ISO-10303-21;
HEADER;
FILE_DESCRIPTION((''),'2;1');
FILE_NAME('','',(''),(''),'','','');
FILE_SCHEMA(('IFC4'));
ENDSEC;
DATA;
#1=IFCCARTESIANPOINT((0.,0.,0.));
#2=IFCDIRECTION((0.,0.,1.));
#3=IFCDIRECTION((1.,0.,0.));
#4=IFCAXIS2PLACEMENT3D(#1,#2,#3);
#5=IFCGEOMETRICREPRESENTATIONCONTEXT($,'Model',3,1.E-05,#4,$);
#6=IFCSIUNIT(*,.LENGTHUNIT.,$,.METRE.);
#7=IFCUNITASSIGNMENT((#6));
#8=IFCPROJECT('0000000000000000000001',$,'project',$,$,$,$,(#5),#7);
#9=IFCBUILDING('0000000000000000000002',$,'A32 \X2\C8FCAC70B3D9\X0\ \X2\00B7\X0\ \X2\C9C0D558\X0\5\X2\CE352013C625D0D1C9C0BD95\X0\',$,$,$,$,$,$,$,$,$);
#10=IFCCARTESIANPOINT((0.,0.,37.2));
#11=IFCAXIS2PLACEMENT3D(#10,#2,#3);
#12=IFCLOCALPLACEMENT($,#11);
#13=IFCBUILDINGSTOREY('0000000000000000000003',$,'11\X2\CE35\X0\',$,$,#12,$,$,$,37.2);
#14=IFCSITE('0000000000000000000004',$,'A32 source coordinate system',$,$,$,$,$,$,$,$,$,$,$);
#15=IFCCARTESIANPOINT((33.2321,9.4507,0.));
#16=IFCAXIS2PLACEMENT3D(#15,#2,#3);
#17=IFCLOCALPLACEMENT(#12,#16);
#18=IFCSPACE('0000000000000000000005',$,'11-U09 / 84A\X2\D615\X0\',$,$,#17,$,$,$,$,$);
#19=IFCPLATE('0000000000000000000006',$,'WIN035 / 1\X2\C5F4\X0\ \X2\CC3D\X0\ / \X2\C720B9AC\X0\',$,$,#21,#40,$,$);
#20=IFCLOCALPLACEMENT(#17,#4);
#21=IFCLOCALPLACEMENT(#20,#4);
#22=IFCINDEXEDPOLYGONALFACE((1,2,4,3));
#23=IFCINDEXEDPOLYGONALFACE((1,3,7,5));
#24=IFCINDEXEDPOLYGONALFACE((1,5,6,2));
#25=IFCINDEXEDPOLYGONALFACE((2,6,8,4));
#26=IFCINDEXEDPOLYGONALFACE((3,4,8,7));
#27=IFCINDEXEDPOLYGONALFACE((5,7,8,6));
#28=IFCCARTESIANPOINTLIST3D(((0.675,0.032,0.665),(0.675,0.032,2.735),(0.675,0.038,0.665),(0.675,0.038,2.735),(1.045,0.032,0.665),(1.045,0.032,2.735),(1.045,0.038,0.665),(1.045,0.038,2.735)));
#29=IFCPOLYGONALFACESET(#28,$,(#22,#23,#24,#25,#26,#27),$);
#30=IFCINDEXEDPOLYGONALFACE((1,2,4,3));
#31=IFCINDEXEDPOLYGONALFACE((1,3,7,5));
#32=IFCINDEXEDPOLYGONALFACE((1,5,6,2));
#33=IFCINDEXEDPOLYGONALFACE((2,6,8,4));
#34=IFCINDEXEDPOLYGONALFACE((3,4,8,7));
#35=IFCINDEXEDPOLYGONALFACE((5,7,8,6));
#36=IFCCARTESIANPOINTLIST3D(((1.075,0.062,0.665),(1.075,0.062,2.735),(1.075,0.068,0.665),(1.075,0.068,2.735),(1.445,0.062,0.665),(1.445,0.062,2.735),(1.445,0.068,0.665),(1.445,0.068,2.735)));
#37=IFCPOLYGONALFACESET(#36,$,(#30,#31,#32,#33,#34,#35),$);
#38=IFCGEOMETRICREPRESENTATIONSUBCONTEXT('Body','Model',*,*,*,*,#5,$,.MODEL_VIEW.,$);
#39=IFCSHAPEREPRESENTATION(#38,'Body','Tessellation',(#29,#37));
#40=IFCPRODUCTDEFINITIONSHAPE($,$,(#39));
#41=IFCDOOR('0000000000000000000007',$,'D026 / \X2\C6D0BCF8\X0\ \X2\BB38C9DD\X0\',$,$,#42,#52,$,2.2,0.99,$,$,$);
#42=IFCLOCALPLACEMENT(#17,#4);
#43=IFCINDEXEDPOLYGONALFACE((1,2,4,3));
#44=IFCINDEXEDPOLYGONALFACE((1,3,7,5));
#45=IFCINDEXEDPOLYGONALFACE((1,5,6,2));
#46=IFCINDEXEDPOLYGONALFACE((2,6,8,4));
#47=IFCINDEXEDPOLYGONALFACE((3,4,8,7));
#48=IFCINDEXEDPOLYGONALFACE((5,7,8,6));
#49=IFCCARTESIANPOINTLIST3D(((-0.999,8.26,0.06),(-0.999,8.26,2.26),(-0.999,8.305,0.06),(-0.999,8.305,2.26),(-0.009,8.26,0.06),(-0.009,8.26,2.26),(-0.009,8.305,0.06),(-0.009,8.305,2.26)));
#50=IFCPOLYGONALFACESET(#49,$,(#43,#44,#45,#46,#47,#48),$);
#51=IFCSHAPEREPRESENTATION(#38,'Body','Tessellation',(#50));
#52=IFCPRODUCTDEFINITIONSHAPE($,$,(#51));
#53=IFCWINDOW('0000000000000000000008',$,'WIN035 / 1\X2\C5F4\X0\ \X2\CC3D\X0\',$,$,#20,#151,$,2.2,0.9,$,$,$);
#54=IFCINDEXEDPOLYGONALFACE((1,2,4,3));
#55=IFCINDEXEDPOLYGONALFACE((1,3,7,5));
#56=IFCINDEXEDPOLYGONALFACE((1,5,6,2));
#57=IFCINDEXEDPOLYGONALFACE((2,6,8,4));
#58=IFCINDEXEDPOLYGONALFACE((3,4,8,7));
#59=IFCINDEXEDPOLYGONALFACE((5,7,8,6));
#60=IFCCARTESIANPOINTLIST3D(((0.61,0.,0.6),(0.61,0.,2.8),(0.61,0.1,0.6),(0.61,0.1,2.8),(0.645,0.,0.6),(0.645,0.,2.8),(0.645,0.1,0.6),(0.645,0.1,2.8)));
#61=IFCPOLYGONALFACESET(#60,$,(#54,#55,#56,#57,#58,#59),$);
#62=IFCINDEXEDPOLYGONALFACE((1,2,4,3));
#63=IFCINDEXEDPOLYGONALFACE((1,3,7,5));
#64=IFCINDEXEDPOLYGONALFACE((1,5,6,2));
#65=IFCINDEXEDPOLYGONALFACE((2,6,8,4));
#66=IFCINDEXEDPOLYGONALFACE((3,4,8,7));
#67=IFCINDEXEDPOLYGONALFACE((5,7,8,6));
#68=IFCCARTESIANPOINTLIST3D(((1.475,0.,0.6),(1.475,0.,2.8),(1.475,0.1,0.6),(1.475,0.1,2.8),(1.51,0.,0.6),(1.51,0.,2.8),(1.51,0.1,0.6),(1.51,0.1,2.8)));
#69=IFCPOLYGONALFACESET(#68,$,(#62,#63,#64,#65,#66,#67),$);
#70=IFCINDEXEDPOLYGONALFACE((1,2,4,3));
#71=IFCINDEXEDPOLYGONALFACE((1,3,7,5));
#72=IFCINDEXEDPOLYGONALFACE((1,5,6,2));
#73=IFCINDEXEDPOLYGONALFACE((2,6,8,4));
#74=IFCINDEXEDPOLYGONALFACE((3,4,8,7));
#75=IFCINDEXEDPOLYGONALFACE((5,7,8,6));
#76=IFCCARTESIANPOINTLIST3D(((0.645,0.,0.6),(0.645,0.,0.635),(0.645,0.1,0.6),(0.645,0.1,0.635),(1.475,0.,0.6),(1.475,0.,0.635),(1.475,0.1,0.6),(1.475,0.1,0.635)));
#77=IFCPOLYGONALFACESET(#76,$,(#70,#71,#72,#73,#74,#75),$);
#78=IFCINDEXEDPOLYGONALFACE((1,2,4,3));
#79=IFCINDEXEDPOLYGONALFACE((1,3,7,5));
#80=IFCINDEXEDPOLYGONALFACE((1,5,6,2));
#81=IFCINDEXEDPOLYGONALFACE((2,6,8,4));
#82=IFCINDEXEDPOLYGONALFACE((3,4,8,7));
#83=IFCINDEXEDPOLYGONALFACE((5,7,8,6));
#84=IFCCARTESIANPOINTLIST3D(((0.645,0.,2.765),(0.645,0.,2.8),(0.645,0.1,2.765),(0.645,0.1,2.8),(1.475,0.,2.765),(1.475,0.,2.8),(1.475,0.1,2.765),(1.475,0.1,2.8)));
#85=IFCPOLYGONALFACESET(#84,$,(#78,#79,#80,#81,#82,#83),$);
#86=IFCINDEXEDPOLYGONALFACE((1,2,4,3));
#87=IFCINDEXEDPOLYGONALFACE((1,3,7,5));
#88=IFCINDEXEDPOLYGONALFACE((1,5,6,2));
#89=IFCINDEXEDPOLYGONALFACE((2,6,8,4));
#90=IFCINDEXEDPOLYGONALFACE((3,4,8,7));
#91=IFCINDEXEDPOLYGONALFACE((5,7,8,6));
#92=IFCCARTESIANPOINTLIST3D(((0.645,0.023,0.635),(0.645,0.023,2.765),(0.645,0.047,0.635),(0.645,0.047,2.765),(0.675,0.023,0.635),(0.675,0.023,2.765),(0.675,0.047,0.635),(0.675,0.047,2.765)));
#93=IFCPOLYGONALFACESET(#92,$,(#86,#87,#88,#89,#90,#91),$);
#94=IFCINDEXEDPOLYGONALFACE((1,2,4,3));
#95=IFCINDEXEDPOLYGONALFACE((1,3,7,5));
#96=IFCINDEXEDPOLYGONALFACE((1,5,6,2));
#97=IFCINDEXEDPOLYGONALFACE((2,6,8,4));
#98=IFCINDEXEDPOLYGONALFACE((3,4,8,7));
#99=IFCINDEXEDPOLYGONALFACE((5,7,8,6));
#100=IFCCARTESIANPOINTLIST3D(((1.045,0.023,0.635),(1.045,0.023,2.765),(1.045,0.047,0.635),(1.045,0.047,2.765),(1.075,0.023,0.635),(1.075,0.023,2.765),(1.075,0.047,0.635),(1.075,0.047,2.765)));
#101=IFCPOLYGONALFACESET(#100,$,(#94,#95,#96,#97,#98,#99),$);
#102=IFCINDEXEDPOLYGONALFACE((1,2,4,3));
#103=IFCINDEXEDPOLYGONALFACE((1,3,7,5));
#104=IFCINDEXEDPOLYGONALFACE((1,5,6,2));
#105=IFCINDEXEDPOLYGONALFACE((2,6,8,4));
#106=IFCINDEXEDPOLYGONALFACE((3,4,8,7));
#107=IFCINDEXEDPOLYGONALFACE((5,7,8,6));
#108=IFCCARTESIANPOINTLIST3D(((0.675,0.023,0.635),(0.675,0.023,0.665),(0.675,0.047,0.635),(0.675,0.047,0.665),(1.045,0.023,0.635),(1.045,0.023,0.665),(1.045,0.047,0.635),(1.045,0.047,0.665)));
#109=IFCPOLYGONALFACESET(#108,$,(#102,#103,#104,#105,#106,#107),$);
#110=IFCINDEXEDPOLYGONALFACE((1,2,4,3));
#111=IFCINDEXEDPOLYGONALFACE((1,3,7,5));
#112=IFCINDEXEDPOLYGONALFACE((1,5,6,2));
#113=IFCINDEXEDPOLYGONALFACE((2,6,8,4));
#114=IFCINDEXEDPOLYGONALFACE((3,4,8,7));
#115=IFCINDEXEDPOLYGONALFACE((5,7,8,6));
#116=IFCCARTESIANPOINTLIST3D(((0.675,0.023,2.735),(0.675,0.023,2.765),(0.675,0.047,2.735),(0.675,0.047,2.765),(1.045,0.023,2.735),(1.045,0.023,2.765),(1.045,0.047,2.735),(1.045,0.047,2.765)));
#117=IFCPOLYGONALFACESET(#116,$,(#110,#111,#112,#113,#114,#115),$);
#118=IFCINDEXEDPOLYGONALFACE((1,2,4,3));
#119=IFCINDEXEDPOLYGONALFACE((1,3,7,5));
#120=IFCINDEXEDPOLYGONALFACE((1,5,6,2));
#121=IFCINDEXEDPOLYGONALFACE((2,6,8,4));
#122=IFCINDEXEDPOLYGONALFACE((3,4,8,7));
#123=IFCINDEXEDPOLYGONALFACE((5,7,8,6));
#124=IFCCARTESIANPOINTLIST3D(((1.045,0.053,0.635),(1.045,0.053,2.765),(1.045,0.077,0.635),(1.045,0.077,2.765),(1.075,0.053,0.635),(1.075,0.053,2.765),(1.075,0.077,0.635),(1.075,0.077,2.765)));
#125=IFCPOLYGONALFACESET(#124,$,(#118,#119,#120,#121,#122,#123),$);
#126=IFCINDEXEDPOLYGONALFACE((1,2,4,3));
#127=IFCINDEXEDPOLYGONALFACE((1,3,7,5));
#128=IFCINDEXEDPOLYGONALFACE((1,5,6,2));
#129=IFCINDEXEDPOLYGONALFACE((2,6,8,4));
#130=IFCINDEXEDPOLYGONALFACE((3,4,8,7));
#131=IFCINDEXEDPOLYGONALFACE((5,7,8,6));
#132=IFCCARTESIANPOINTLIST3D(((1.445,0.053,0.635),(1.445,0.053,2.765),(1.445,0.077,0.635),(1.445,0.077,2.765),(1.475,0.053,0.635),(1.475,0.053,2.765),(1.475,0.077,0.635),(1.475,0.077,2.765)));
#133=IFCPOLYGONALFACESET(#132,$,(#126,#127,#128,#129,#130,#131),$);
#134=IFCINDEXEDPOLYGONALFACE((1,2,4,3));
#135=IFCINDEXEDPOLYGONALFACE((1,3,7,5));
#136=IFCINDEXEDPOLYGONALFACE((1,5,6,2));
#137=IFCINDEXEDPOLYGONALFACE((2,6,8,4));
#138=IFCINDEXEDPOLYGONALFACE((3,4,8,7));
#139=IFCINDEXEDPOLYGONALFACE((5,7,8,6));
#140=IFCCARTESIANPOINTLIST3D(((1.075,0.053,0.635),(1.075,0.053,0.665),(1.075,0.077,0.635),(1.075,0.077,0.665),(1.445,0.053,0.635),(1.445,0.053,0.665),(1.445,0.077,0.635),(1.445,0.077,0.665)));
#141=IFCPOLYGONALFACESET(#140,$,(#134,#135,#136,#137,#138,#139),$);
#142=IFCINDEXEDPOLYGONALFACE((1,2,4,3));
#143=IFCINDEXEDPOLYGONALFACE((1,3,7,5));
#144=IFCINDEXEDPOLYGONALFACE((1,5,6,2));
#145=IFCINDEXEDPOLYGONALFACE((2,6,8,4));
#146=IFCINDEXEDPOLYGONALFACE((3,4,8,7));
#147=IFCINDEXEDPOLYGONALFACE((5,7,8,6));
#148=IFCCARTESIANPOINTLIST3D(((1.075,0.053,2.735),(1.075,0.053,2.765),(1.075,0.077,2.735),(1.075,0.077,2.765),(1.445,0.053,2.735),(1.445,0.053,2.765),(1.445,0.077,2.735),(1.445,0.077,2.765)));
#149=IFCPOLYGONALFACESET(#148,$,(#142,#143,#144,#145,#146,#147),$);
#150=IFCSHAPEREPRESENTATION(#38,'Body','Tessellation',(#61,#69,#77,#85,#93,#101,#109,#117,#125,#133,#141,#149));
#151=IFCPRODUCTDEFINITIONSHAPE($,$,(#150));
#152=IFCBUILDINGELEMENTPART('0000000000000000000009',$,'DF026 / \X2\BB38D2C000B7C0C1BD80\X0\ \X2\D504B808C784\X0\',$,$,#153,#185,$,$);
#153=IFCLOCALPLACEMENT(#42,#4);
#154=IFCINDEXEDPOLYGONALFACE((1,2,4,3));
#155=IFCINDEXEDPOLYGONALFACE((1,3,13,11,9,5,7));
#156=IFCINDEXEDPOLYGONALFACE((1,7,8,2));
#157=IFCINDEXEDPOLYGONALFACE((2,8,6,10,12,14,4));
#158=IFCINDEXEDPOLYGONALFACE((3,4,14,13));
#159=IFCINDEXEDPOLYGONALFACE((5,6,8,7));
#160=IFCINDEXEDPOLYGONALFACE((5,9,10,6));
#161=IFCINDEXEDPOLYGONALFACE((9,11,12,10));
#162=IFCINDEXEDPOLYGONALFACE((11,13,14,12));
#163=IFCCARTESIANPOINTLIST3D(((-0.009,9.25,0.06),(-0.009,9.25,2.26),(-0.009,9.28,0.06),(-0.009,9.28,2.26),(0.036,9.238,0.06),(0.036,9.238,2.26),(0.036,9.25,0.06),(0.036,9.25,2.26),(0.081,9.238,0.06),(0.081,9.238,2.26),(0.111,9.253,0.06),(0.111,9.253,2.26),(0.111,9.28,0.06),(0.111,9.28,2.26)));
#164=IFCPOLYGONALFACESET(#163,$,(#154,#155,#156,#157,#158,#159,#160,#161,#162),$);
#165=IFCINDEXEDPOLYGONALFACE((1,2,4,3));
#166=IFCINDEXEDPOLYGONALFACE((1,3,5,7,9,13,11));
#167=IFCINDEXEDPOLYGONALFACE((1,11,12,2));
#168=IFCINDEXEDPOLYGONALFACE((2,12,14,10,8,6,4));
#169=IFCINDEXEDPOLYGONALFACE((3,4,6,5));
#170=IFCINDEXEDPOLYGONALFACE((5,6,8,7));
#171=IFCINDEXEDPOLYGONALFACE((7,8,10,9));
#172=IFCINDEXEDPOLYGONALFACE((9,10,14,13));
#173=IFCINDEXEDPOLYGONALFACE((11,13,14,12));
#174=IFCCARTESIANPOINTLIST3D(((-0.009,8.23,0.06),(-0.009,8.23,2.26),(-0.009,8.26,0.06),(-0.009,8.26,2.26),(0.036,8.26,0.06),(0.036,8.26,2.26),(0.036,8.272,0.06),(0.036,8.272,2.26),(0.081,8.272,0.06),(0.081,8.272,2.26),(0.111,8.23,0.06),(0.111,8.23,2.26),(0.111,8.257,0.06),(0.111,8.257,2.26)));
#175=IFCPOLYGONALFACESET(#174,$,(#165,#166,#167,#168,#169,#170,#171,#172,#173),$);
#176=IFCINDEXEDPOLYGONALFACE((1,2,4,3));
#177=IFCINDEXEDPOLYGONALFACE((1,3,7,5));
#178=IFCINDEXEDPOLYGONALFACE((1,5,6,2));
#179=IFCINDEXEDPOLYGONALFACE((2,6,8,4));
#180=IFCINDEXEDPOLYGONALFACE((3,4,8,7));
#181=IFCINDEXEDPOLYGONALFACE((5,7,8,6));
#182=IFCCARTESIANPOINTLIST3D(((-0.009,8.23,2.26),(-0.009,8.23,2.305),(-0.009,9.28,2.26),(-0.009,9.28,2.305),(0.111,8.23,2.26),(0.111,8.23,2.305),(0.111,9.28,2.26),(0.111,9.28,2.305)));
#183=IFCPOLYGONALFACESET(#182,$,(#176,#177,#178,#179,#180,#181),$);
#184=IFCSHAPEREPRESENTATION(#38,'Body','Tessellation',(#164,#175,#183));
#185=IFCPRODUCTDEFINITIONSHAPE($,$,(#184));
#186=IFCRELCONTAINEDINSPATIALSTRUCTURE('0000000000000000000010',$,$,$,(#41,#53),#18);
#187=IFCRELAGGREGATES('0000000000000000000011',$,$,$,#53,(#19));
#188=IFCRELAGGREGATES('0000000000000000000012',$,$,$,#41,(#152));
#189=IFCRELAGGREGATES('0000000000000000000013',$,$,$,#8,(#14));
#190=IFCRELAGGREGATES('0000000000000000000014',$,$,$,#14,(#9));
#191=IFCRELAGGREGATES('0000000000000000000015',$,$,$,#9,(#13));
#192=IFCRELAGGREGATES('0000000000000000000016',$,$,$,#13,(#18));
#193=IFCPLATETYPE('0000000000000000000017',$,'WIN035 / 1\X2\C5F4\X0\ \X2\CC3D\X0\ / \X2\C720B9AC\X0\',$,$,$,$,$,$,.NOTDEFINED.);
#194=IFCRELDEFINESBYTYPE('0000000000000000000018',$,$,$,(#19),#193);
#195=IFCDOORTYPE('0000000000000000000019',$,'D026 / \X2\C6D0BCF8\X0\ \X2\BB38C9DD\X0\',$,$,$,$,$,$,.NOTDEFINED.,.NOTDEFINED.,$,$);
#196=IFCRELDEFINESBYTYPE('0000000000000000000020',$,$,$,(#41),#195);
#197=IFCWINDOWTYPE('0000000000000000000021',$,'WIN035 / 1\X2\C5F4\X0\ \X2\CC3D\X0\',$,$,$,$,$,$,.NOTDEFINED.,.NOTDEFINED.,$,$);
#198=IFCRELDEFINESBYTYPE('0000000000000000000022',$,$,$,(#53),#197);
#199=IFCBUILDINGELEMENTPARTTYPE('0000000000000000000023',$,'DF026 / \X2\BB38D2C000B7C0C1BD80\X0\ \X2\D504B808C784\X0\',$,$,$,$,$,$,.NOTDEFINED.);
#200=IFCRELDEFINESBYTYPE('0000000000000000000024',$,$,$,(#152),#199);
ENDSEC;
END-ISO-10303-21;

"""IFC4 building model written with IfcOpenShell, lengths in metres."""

from ifc_helpers import new_model, si_unit, frame, origin, origin_with_axes, place, context, subcontext, project, spatial, polyline, outline, extrude, source, transform, mapped, type_object, type_shapes, element, aggregate, save


model = new_model("IFC4")

# Units and contexts
model_context = context("Model", 3, precision=1e-05, world=origin_with_axes())
body_context = subcontext(model_context, "Body", "Model", "MODEL_VIEW")
ifc_project = project(units=[si_unit("LENGTHUNIT", "METRE")], contexts=[model_context])

# Plate
plate_type_1 = type_object("IfcPlateType", Name="WIN035 / 1열 창 / 유리", PredefinedType="NOTDEFINED")
shared_shape_1 = source(origin(), body_context, "Body", "SweptSolid", [
    extrude(outline(polyline([(0.675, 0.032), (0.675, 0.038), (1.045, 0.038), (1.045, 0.032), (0.675, 0.032)])), frame((0.0, 0.0, 0.665)), (0.0, 0.0, 1.0), 2.07),
    extrude(outline(polyline([(1.075, 0.062), (1.075, 0.068), (1.445, 0.068), (1.445, 0.062), (1.075, 0.062)])), frame((0.0, 0.0, 0.665)), (0.0, 0.0, 1.0), 2.07),
])
type_shapes(plate_type_1, [shared_shape_1])
storey_placement = place(None, frame((0.0, 0.0, 37.2), z_axis=(0.0, 0.0, 1.0), x_axis=(1.0, 0.0, 0.0)))
space_placement = place(storey_placement, frame((33.2321, 9.4507, 0.0), z_axis=(0.0, 0.0, 1.0), x_axis=(1.0, 0.0, 0.0)))
window_1_placement = place(space_placement, origin_with_axes())
plate_1_placement = place(window_1_placement, origin_with_axes())
plate_1 = element("IfcPlate", 1, at=plate_1_placement, type_object=plate_type_1, Name="WIN035 / 1열 창 / 유리", context=body_context, shape_type="MappedRepresentation", body=[
    mapped(shared_shape_1, transform((0.0, 0.0, 0.0), scale=1.0)),
])

# Site, building, storey, space
site = spatial("IfcSite", under=ifc_project, Name="A32 source coordinate system")
building = spatial("IfcBuilding", under=site, Name="A32 주거동 · 지하5층–옥탑지붕")
storey = spatial("IfcBuildingStorey", under=building, at=storey_placement, Name="11층", Elevation=37.2)
space = spatial("IfcSpace", under=storey, at=space_placement, Name="11-U09 / 84A형")

# Door
door_type_1 = type_object("IfcDoorType", Name="D026 / 원본 문짝", OperationType="NOTDEFINED", PredefinedType="NOTDEFINED")
shared_shape_2 = source(origin(), body_context, "Body", "SweptSolid", [
    extrude(outline(polyline([(-0.009, 8.26), (-0.999, 8.26), (-0.999, 8.305), (-0.009, 8.305), (-0.009, 8.26)])), frame((0.0, 0.0, 0.06)), (0.0, 0.0, 1.0), 2.2),
])
type_shapes(door_type_1, [shared_shape_2])
door_1_placement = place(space_placement, origin_with_axes())
door_1 = element("IfcDoor", 2, at=door_1_placement, inside=space, type_object=door_type_1, Name="D026 / 원본 문짝", OverallHeight=2.2, OverallWidth=0.99, context=body_context, shape_type="MappedRepresentation", body=[
    mapped(shared_shape_2, transform((0.0, 0.0, 0.0), scale=1.0)),
])

# Window
window_type_1 = type_object("IfcWindowType", Name="WIN035 / 1열 창", PartitioningType="NOTDEFINED", PredefinedType="NOTDEFINED")
shared_shape_3 = source(origin(), body_context, "Body", "SweptSolid", [
    extrude(outline(polyline([(0.61, 0.0), (0.61, 0.1), (0.645, 0.1), (0.645, 0.0), (0.61, 0.0)])), frame((0.0, 0.0, 0.6)), (0.0, 0.0, 1.0), 2.2),
    extrude(outline(polyline([(1.475, 0.0), (1.475, 0.1), (1.51, 0.1), (1.51, 0.0), (1.475, 0.0)])), frame((0.0, 0.0, 0.6)), (0.0, 0.0, 1.0), 2.2),
    extrude(outline(polyline([(0.645, 0.0), (0.645, 0.1), (1.475, 0.1), (1.475, 0.0), (0.645, 0.0)])), frame((0.0, 0.0, 0.6)), (0.0, 0.0, 1.0), 0.035),
    extrude(outline(polyline([(0.645, 0.0), (0.645, 0.1), (1.475, 0.1), (1.475, 0.0), (0.645, 0.0)])), frame((0.0, 0.0, 2.765)), (0.0, 0.0, 1.0), 0.035),
    extrude(outline(polyline([(0.645, 0.023), (0.645, 0.047), (0.675, 0.047), (0.675, 0.023), (0.645, 0.023)])), frame((0.0, 0.0, 0.635)), (0.0, 0.0, 1.0), 2.13),
    extrude(outline(polyline([(1.045, 0.023), (1.045, 0.047), (1.075, 0.047), (1.075, 0.023), (1.045, 0.023)])), frame((0.0, 0.0, 0.635)), (0.0, 0.0, 1.0), 2.13),
    extrude(outline(polyline([(0.675, 0.023), (0.675, 0.047), (1.045, 0.047), (1.045, 0.023), (0.675, 0.023)])), frame((0.0, 0.0, 0.635)), (0.0, 0.0, 1.0), 0.03),
    extrude(outline(polyline([(0.675, 0.023), (0.675, 0.047), (1.045, 0.047), (1.045, 0.023), (0.675, 0.023)])), frame((0.0, 0.0, 2.735)), (0.0, 0.0, 1.0), 0.03),
    extrude(outline(polyline([(1.045, 0.053), (1.045, 0.077), (1.075, 0.077), (1.075, 0.053), (1.045, 0.053)])), frame((0.0, 0.0, 0.635)), (0.0, 0.0, 1.0), 2.13),
    extrude(outline(polyline([(1.445, 0.053), (1.445, 0.077), (1.475, 0.077), (1.475, 0.053), (1.445, 0.053)])), frame((0.0, 0.0, 0.635)), (0.0, 0.0, 1.0), 2.13),
    extrude(outline(polyline([(1.075, 0.053), (1.075, 0.077), (1.445, 0.077), (1.445, 0.053), (1.075, 0.053)])), frame((0.0, 0.0, 0.635)), (0.0, 0.0, 1.0), 0.03),
    extrude(outline(polyline([(1.075, 0.053), (1.075, 0.077), (1.445, 0.077), (1.445, 0.053), (1.075, 0.053)])), frame((0.0, 0.0, 2.735)), (0.0, 0.0, 1.0), 0.03),
])
type_shapes(window_type_1, [shared_shape_3])
window_1 = element("IfcWindow", 3, at=window_1_placement, inside=space, type_object=window_type_1, Name="WIN035 / 1열 창", OverallHeight=2.2, OverallWidth=0.9, context=body_context, shape_type="MappedRepresentation", body=[
    mapped(shared_shape_3, transform((0.0, 0.0, 0.0), scale=1.0)),
])
aggregate(window_1, [plate_1])

# Building element part
building_element_part_type_1 = type_object("IfcBuildingElementPartType", Name="DF026 / 문틀·상부 프레임", PredefinedType="NOTDEFINED")
shared_shape_4 = source(origin(), body_context, "Body", "SweptSolid", [
    extrude(outline(polyline([(0.111, 9.28), (0.111, 9.253), (0.081, 9.238), (0.036, 9.238), (0.036, 9.25), (-0.009, 9.25), (-0.009, 9.28), (0.111, 9.28)])), frame((0.0, 0.0, 0.06)), (0.0, 0.0, 1.0), 2.2),
    extrude(outline(polyline([(-0.009, 8.26), (0.036, 8.26), (0.036, 8.272), (0.081, 8.272), (0.111, 8.257), (0.111, 8.23), (-0.009, 8.23), (-0.009, 8.26)])), frame((0.0, 0.0, 0.06)), (0.0, 0.0, 1.0), 2.2),
    extrude(outline(polyline([(-0.009, 8.23), (-0.009, 9.28), (0.111, 9.28), (0.111, 8.23), (-0.009, 8.23)])), frame((0.0, 0.0, 2.26)), (0.0, 0.0, 1.0), 0.045),
])
type_shapes(building_element_part_type_1, [shared_shape_4])
building_element_part_1_placement = place(door_1_placement, origin_with_axes())
building_element_part_1 = element("IfcBuildingElementPart", 4, at=building_element_part_1_placement, type_object=building_element_part_type_1, Name="DF026 / 문틀·상부 프레임", context=body_context, shape_type="MappedRepresentation", body=[
    mapped(shared_shape_4, transform((0.0, 0.0, 0.0), scale=1.0)),
])
aggregate(door_1, [building_element_part_1])

save(model, "model.ifc")
